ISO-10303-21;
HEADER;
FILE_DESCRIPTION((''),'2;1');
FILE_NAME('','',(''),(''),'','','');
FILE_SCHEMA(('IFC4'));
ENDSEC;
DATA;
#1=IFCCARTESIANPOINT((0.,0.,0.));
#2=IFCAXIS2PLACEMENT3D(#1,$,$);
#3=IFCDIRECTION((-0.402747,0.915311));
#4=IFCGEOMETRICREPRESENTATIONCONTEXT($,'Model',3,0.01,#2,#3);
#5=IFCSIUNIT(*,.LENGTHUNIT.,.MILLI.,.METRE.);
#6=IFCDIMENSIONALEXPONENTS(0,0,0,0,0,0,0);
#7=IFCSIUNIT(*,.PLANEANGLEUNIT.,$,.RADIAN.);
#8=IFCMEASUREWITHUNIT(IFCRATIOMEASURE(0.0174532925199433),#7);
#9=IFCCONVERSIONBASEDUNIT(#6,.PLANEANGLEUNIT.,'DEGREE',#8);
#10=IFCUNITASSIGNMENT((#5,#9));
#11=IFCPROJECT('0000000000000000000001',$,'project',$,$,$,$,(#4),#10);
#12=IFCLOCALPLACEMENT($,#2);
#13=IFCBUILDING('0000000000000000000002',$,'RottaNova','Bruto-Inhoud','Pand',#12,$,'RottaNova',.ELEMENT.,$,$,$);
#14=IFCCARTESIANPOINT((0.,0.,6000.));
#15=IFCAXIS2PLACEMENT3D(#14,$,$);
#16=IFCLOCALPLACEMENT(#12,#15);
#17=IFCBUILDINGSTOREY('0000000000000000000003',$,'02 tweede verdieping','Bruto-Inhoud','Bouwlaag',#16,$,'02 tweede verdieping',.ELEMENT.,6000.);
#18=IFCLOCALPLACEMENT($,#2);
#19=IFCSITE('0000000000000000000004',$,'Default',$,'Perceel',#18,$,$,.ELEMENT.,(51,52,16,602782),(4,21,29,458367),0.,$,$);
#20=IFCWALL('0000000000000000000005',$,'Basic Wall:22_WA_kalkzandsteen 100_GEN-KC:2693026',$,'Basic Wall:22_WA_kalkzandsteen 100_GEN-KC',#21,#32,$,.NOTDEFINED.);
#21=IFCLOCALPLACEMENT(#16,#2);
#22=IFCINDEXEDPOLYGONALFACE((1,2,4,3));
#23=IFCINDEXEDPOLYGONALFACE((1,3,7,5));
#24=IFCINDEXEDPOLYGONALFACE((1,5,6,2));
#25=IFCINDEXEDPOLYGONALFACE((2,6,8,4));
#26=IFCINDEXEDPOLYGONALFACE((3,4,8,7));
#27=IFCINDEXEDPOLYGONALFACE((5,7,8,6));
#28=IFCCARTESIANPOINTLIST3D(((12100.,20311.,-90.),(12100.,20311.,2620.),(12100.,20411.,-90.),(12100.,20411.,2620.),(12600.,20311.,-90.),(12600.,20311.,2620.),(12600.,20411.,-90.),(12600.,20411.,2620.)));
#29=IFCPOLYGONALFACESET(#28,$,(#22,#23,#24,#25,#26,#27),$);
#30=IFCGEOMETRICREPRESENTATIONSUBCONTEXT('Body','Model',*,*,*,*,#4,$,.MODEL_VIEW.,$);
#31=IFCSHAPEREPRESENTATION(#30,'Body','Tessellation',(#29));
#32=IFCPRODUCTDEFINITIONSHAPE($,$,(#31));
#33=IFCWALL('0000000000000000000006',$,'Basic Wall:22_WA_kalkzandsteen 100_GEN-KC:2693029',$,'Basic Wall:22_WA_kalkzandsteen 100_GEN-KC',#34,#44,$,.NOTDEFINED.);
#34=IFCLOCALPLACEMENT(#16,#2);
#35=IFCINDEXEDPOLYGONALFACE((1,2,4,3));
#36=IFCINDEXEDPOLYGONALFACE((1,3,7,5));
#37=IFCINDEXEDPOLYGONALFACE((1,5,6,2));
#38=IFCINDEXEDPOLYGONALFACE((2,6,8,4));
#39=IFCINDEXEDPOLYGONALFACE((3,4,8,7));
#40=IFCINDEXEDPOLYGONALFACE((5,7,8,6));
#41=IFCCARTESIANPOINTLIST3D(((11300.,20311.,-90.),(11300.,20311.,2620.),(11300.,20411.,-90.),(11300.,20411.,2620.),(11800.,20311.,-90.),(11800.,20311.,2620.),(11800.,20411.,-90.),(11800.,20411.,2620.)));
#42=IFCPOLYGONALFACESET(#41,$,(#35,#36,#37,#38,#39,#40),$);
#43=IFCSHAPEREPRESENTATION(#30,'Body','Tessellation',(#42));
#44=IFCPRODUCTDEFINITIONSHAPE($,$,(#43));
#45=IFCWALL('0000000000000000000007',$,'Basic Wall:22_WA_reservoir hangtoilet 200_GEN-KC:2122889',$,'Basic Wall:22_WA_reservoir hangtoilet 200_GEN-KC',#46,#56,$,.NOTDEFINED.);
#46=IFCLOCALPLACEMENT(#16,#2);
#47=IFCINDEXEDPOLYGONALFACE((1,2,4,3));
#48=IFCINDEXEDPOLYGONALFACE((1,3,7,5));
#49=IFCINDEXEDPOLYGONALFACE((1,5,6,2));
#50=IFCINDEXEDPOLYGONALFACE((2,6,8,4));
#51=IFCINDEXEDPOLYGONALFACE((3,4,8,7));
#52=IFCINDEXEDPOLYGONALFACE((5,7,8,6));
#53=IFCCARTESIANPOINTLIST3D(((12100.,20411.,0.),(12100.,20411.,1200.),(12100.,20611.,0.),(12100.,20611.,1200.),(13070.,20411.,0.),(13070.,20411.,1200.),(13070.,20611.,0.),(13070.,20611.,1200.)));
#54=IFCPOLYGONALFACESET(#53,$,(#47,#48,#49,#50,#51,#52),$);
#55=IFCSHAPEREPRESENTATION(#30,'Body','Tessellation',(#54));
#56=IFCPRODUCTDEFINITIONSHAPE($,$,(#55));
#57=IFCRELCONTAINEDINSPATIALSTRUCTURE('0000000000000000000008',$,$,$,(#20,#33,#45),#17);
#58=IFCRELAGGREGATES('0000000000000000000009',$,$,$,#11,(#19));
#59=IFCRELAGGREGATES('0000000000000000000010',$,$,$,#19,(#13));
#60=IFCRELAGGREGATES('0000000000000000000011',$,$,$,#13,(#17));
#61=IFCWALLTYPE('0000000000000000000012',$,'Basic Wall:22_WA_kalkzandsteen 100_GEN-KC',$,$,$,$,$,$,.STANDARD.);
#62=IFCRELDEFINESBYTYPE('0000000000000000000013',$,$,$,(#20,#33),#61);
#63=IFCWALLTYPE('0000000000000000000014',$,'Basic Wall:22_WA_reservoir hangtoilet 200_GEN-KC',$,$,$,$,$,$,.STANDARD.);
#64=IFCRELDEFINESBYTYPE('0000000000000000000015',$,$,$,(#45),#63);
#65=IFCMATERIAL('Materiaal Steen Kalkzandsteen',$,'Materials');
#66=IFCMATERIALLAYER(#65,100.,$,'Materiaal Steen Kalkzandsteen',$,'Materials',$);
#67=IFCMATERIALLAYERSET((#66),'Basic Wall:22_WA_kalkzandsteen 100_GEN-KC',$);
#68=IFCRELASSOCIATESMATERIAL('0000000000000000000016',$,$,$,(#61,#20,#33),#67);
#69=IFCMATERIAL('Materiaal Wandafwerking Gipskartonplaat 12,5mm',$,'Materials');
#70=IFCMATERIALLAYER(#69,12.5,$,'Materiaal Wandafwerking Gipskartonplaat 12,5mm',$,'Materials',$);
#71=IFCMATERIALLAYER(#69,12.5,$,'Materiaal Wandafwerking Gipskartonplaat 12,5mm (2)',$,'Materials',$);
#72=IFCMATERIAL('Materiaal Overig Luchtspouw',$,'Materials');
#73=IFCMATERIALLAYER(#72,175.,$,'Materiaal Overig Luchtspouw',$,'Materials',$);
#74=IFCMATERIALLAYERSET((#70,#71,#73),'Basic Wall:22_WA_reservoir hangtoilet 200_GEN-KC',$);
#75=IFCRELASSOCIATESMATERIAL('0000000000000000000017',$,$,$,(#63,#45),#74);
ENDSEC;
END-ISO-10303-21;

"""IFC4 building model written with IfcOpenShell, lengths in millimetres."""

from ifc_helpers import new_model, entity, si_unit, converted_unit, direction, frame, frame_2d, origin, place, context, subcontext, project, spatial, rectangle, extrude, material, layer, layer_set, type_object, element, save


model = new_model("IFC4")

# Units and contexts
model_context = context("Model", 3, precision=0.01, world=origin(), true_north=direction((-0.402747, 0.915311)))
body_context = subcontext(model_context, "Body", "Model", "MODEL_VIEW")
ifc_project = project(units=[si_unit("LENGTHUNIT", "METRE", prefix="MILLI"), converted_unit("PLANEANGLEUNIT", "DEGREE", entity("IfcRatioMeasure", 0.0174532925199433), si_unit("PLANEANGLEUNIT", "RADIAN"), dimensions=[0, 0, 0, 0, 0, 0, 0])], contexts=[model_context])

# Site, building, storey
site_placement = place(None, origin())
site = spatial("IfcSite", under=ifc_project, at=site_placement, Name="Default", ObjectType="Perceel", CompositionType="ELEMENT", RefLatitude=(51, 52, 16, 602782), RefLongitude=(4, 21, 29, 458367), RefElevation=0.0)
building_placement = place(None, origin())
building = spatial("IfcBuilding", under=site, at=building_placement, Name="RottaNova", Description="Bruto-Inhoud", ObjectType="Pand", LongName="RottaNova", CompositionType="ELEMENT")
storey_placement = place(building_placement, frame((0.0, 0.0, 6000.0)))
storey = spatial("IfcBuildingStorey", under=building, at=storey_placement, Name="02 tweede verdieping", Description="Bruto-Inhoud", ObjectType="Bouwlaag", LongName="02 tweede verdieping", CompositionType="ELEMENT", Elevation=6000.0)

# Shared definitions
ifc_material_1 = material(Name="Materiaal Steen Kalkzandsteen", Category="Materials")

# Walls
ifc_layer_1 = layer(ifc_material_1, 100.0, Name="Materiaal Steen Kalkzandsteen", Category="Materials")
ifc_layer_set_1 = layer_set([ifc_layer_1], Name="Basic Wall:22_WA_kalkzandsteen 100_GEN-KC")
wall_type_1 = type_object("IfcWallType", Name="Basic Wall:22_WA_kalkzandsteen 100_GEN-KC", PredefinedType="STANDARD", material=ifc_layer_set_1)
wall_1_placement = place(storey_placement, frame((12600.0, 20361.0, -90.0), z_axis=(0.0, 0.0, 1.0), x_axis=(-1.0, 0.0, 0.0)))
element("IfcWall", 1, at=wall_1_placement, inside=storey, type_object=wall_type_1, material=ifc_layer_set_1, Name="Basic Wall:22_WA_kalkzandsteen 100_GEN-KC:2693026", ObjectType="Basic Wall:22_WA_kalkzandsteen 100_GEN-KC", PredefinedType="NOTDEFINED", context=body_context, shape_type="SweptSolid", body=[
    extrude(rectangle(XDim=500.0, YDim=100.0, at=frame_2d((250.0, 0.0), x_axis=(-1.0, 0.0))), origin(), (0.0, 0.0, 1.0), 2710.0),
])
wall_2_placement = place(storey_placement, frame((11300.0, 20361.0, -90.0)))
element("IfcWall", 2, at=wall_2_placement, inside=storey, type_object=wall_type_1, material=ifc_layer_set_1, Name="Basic Wall:22_WA_kalkzandsteen 100_GEN-KC:2693029", ObjectType="Basic Wall:22_WA_kalkzandsteen 100_GEN-KC", PredefinedType="NOTDEFINED", context=body_context, shape_type="SweptSolid", body=[
    extrude(rectangle(XDim=500.0, YDim=100.0, at=frame_2d((250.0, 0.0), x_axis=(-1.0, 0.0))), origin(), (0.0, 0.0, 1.0), 2710.0),
])
ifc_material_2 = material(Name="Materiaal Wandafwerking Gipskartonplaat 12,5mm", Category="Materials")
ifc_layer_2 = layer(ifc_material_2, 12.5, Name="Materiaal Wandafwerking Gipskartonplaat 12,5mm", Category="Materials")
ifc_layer_3 = layer(ifc_material_2, 12.5, Name="Materiaal Wandafwerking Gipskartonplaat 12,5mm (2)", Category="Materials")
ifc_material_3 = material(Name="Materiaal Overig Luchtspouw", Category="Materials")
ifc_layer_4 = layer(ifc_material_3, 175.0, Name="Materiaal Overig Luchtspouw", Category="Materials")
ifc_layer_set_2 = layer_set([ifc_layer_2, ifc_layer_3, ifc_layer_4], Name="Basic Wall:22_WA_reservoir hangtoilet 200_GEN-KC")
wall_type_2 = type_object("IfcWallType", Name="Basic Wall:22_WA_reservoir hangtoilet 200_GEN-KC", PredefinedType="STANDARD", material=ifc_layer_set_2)
wall_3_placement = place(storey_placement, frame((13070.0, 20511.0, 0.0), z_axis=(0.0, 0.0, 1.0), x_axis=(-1.0, 0.0, 0.0)))
element("IfcWall", 3, at=wall_3_placement, inside=storey, type_object=wall_type_2, material=ifc_layer_set_2, Name="Basic Wall:22_WA_reservoir hangtoilet 200_GEN-KC:2122889", ObjectType="Basic Wall:22_WA_reservoir hangtoilet 200_GEN-KC", PredefinedType="NOTDEFINED", context=body_context, shape_type="SweptSolid", body=[
    extrude(rectangle(XDim=970.0, YDim=200.0, at=frame_2d((485.0, 0.0), x_axis=(-1.0, 0.0))), origin(), (0.0, 0.0, 1.0), 1200.0),
])

save(model, "model.ifc")
